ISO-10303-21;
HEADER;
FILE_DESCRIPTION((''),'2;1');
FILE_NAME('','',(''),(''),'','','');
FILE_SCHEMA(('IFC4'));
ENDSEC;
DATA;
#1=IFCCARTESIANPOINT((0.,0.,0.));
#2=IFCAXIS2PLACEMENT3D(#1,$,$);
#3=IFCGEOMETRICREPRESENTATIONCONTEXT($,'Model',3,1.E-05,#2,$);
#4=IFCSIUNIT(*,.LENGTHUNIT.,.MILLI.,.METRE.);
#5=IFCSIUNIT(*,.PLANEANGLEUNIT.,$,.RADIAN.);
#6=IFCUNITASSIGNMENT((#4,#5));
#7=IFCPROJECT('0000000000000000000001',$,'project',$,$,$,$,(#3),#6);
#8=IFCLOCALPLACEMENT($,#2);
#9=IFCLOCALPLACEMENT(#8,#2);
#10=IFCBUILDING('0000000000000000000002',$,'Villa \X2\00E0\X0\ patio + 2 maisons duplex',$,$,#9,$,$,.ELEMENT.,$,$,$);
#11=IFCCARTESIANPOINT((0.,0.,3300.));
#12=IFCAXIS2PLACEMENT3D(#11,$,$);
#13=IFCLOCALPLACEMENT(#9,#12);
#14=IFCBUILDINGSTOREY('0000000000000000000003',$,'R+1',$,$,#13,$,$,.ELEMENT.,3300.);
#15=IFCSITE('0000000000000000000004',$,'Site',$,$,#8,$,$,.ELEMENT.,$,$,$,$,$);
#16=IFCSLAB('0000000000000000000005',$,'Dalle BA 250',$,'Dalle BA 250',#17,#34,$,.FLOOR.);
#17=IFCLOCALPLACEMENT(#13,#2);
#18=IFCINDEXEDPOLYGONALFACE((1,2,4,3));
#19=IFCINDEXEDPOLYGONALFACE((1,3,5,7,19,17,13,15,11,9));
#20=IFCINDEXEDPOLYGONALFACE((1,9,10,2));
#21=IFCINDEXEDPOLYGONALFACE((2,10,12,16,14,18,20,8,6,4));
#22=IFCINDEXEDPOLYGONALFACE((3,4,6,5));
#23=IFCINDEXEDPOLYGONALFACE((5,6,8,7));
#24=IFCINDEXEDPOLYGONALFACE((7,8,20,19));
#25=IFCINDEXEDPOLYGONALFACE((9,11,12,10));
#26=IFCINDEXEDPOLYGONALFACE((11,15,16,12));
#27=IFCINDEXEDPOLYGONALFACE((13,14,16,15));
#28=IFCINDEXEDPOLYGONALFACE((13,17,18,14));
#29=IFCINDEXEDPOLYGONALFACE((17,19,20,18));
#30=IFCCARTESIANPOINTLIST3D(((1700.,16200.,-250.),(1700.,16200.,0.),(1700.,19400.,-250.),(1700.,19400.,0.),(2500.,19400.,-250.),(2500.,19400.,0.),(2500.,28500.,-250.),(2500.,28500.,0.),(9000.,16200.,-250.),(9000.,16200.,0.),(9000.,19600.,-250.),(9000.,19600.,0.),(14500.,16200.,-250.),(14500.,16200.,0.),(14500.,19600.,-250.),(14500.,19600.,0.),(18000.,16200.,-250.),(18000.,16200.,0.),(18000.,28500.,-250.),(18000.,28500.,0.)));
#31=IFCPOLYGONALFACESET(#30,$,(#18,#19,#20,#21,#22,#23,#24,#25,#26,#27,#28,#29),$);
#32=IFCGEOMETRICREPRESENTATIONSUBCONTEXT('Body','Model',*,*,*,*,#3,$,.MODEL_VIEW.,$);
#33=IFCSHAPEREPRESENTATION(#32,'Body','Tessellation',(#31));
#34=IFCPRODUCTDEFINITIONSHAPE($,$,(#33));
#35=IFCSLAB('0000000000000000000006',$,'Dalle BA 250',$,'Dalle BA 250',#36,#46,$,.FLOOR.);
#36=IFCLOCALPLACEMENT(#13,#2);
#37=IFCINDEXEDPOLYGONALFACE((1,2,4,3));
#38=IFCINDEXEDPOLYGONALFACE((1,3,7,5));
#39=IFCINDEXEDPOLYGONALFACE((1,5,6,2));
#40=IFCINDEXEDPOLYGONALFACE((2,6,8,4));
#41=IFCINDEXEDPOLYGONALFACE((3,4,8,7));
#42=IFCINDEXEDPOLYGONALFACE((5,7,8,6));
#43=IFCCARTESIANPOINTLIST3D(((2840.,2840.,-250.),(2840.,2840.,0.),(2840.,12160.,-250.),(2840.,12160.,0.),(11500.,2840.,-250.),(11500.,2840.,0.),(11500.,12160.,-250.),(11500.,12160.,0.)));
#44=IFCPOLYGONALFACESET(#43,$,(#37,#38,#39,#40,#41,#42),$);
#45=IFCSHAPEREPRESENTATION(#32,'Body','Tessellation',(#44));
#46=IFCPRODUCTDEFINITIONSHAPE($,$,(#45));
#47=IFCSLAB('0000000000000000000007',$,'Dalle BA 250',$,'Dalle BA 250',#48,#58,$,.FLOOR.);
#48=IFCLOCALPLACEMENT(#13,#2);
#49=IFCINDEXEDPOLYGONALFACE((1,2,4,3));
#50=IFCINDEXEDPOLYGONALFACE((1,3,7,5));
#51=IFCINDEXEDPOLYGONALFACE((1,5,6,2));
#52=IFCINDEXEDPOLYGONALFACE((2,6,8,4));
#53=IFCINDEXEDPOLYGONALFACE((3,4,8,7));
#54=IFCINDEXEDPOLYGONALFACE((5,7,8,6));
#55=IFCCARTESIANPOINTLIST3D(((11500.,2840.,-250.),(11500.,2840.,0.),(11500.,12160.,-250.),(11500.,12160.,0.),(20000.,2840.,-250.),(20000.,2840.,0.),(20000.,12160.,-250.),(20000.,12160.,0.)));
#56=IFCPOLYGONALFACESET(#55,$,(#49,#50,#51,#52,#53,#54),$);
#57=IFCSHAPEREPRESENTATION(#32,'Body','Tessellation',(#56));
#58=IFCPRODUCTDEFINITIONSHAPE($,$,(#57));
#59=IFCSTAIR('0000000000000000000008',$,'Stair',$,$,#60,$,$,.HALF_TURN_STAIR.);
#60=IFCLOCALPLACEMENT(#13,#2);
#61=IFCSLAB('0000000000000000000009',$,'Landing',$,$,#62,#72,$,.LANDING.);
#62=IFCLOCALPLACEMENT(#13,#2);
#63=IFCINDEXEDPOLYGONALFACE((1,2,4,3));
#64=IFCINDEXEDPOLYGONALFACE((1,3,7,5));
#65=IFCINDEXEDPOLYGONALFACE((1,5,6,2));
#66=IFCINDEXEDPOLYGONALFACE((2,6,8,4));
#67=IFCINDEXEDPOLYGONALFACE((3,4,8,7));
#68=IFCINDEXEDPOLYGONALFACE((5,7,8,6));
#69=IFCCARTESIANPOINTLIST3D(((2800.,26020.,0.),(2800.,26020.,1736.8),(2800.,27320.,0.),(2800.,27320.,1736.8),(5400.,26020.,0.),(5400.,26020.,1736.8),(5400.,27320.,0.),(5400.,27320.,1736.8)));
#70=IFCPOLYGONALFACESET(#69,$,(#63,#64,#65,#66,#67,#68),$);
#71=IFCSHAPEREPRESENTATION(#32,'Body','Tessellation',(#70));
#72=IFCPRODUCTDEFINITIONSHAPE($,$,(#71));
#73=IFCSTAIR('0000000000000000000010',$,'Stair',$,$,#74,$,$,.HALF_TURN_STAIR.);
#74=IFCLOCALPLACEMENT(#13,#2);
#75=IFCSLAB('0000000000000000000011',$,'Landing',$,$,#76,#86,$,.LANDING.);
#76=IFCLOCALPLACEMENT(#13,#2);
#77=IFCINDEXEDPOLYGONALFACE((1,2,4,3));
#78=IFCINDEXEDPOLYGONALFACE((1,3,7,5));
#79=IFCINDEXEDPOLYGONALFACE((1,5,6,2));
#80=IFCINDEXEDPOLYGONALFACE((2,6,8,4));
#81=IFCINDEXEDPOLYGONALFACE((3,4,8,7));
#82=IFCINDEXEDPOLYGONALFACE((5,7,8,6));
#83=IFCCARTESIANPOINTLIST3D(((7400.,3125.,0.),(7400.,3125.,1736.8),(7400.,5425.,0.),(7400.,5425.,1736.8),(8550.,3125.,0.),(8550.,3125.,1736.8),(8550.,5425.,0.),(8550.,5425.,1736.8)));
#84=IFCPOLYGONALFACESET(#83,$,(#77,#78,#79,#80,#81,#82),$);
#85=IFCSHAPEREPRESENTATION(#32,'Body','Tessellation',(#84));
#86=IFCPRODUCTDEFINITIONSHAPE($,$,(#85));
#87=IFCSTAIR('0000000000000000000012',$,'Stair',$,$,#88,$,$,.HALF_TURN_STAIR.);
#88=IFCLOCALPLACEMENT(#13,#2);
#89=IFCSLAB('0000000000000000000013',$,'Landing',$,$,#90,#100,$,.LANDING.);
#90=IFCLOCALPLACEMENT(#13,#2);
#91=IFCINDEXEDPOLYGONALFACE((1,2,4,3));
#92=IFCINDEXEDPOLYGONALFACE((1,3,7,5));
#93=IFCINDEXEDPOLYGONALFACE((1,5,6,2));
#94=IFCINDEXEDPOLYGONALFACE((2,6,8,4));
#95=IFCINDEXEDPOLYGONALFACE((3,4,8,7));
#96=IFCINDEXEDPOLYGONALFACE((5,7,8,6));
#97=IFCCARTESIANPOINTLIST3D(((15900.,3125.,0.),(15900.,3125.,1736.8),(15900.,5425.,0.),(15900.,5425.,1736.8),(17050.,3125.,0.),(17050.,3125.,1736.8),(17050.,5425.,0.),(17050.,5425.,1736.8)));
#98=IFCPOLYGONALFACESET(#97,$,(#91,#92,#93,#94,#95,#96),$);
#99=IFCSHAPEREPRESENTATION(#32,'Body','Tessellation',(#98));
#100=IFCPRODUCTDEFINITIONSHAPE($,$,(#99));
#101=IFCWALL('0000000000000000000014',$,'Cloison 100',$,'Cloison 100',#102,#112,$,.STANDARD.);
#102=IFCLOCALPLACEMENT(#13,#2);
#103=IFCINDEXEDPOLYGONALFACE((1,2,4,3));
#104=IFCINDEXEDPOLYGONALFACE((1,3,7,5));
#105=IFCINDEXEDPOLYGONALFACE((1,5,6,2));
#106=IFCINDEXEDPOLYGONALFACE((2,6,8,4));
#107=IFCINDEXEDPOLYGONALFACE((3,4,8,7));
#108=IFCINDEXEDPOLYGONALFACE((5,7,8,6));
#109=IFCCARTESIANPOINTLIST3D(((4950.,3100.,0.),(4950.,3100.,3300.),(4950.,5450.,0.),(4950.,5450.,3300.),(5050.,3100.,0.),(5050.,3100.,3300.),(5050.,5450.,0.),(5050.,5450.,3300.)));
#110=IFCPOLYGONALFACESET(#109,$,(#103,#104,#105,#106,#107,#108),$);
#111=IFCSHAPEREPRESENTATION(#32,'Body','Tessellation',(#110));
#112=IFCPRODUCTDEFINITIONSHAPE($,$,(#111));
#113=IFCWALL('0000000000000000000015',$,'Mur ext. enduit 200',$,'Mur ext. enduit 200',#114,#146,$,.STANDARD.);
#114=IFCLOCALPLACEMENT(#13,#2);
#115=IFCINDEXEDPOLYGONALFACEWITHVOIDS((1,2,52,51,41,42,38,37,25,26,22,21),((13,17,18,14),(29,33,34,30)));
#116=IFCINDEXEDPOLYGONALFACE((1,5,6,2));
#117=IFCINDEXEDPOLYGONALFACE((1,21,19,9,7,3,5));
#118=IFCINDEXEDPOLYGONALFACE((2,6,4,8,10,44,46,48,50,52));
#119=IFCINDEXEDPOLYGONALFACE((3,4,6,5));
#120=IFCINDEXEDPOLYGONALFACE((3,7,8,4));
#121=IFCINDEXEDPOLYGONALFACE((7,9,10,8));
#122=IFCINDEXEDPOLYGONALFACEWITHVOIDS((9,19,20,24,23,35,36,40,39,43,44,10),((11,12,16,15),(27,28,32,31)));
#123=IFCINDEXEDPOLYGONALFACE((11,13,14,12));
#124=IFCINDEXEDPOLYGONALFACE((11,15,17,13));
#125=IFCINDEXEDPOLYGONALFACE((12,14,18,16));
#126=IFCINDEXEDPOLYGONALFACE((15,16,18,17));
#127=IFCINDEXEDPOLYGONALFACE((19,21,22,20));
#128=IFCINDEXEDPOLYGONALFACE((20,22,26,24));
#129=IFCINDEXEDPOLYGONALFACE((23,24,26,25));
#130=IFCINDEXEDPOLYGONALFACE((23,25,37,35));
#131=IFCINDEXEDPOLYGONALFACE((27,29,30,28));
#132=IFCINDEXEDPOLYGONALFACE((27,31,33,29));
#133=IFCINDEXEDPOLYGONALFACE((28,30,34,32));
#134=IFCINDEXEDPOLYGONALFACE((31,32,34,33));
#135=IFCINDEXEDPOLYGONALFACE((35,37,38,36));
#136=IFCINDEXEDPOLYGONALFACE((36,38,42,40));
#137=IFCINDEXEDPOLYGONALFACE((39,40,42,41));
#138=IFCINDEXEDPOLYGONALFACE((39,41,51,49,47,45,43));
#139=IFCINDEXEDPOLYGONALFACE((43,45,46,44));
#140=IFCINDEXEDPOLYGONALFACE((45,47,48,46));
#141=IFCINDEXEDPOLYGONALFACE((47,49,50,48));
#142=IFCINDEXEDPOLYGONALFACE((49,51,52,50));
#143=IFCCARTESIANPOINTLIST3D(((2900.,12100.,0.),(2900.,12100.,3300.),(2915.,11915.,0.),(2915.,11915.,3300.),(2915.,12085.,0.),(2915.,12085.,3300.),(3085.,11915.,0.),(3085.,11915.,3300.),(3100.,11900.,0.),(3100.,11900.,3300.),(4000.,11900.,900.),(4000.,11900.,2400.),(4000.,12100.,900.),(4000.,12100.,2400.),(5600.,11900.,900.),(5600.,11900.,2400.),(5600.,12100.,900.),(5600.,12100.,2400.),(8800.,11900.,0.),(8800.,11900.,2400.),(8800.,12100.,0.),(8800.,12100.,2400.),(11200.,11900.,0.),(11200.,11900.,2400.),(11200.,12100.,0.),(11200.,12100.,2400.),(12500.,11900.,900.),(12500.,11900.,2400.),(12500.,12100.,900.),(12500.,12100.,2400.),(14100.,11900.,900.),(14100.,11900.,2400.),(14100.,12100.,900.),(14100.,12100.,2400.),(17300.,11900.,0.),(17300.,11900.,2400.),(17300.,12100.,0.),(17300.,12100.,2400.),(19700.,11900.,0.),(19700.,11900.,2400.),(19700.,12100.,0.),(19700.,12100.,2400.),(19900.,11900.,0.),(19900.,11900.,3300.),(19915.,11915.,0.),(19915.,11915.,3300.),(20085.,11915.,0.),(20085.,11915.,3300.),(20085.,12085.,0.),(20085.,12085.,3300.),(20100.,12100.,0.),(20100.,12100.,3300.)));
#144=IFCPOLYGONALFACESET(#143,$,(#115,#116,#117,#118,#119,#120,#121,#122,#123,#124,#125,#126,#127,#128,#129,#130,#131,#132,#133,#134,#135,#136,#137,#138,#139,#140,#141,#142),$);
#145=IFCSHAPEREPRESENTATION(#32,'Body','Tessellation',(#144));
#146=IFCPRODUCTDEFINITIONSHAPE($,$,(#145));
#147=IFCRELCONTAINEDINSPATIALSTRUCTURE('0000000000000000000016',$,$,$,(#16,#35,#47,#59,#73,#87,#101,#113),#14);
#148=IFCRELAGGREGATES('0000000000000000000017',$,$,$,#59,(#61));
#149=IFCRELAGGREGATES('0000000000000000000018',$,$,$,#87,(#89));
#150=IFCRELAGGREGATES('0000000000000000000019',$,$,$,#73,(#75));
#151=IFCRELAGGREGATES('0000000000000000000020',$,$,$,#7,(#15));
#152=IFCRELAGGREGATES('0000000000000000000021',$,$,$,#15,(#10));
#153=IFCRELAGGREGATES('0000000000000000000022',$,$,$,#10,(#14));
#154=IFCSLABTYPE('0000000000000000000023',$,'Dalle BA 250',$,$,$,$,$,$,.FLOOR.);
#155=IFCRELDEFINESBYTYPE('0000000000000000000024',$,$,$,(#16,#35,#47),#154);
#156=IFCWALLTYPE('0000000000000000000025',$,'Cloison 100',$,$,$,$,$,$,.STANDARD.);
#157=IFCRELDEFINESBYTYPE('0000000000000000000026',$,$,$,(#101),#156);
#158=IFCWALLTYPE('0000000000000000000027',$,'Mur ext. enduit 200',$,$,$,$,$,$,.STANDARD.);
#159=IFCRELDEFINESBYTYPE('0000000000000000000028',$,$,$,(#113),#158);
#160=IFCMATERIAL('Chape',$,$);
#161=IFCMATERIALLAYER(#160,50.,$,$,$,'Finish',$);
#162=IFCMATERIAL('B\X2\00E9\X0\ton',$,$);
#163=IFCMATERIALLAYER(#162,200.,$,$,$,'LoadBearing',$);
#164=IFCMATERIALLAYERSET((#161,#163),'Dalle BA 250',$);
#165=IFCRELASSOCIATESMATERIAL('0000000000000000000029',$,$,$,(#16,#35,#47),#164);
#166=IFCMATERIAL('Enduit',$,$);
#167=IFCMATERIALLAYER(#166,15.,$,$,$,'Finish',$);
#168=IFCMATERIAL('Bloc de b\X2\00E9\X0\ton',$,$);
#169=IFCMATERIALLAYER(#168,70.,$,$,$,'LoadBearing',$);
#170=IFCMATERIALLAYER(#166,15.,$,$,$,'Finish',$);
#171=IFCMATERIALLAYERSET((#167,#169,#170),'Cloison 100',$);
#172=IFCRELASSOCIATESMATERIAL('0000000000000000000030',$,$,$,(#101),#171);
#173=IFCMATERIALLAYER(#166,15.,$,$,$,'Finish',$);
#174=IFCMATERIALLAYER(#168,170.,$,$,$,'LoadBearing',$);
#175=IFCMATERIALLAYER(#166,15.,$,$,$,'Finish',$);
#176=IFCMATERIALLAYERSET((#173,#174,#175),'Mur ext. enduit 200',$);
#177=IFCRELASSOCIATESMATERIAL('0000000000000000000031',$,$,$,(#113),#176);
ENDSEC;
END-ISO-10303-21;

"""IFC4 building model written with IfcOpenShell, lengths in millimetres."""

from ifc_helpers import new_model, si_unit, frame, frame_2d, origin, place, context, subcontext, project, spatial, polyline, rectangle, outline, extrude, material, layer, layer_set, layer_usage, type_object, element, aggregate, save


model = new_model("IFC4")

# Units and contexts
model_context = context("Model", 3, precision=1e-05, world=origin())
body_context = subcontext(model_context, "Body", "Model", "MODEL_VIEW")
ifc_project = project(units=[si_unit("LENGTHUNIT", "METRE", prefix="MILLI"), si_unit("PLANEANGLEUNIT", "RADIAN")], contexts=[model_context])

# Site, building, storey
site_placement = place(None, origin())
site = spatial("IfcSite", under=ifc_project, at=site_placement, Name="Site", CompositionType="ELEMENT")
building_placement = place(site_placement, origin())
building = spatial("IfcBuilding", under=site, at=building_placement, Name="Villa à patio + 2 maisons duplex", CompositionType="ELEMENT")
storey_placement = place(building_placement, frame((0.0, 0.0, 3300.0)))
storey = spatial("IfcBuildingStorey", under=building, at=storey_placement, Name="R+1", CompositionType="ELEMENT", Elevation=3300.0)

# Slabs
ifc_material_1 = material(Name="Chape")
ifc_layer_1 = layer(ifc_material_1, 50.0, Category="Finish")
ifc_material_2 = material(Name="Béton")
ifc_layer_2 = layer(ifc_material_2, 200.0, Category="LoadBearing")
ifc_layer_set_1 = layer_set([ifc_layer_1, ifc_layer_2], Name="Dalle BA 250")
ifc_layer_usage_1 = layer_usage(ifc_layer_set_1, "AXIS3", "NEGATIVE", 0.0)
slab_type = type_object("IfcSlabType", Name="Dalle BA 250", PredefinedType="FLOOR")
slab_1_placement = place(storey_placement, origin())
element("IfcSlab", 1, at=slab_1_placement, inside=storey, type_object=slab_type, material=ifc_layer_usage_1, Name="Dalle BA 250", ObjectType="Dalle BA 250", PredefinedType="FLOOR", context=body_context, shape_type="SweptSolid", body=[
    extrude(outline(polyline([(2500.0, 28500.0), (2500.0, 19400.0), (1700.0, 19400.0), (1700.0, 16200.0), (9000.0, 16200.0), (9000.0, 19600.0), (14500.0, 19600.0), (14500.0, 16200.0), (18000.0, 16200.0), (18000.0, 28500.0), (2500.0, 28500.0)])), frame((0.0, 0.0, -250.0)), (0.0, 0.0, 1.0), 250.0),
])
slab_2_placement = place(storey_placement, origin())
element("IfcSlab", 2, at=slab_2_placement, inside=storey, type_object=slab_type, material=ifc_layer_usage_1, Name="Dalle BA 250", ObjectType="Dalle BA 250", PredefinedType="FLOOR", context=body_context, shape_type="SweptSolid", body=[
    extrude(outline(polyline([(2840.0, 12160.0), (2840.0, 2840.0), (11500.0, 2840.0), (11500.0, 12160.0), (2840.0, 12160.0)])), frame((0.0, 0.0, -250.0)), (0.0, 0.0, 1.0), 250.0),
])
slab_3_placement = place(storey_placement, origin())
element("IfcSlab", 3, at=slab_3_placement, inside=storey, type_object=slab_type, material=ifc_layer_usage_1, Name="Dalle BA 250", ObjectType="Dalle BA 250", PredefinedType="FLOOR", context=body_context, shape_type="SweptSolid", body=[
    extrude(outline(polyline([(11500.0, 12160.0), (11500.0, 2840.0), (20000.0, 2840.0), (20000.0, 12160.0), (11500.0, 12160.0)])), frame((0.0, 0.0, -250.0)), (0.0, 0.0, 1.0), 250.0),
])

# Stairs, slabs
stair_1_placement = place(storey_placement, origin())
stair_1 = element("IfcStair", 4, at=stair_1_placement, inside=storey, Name="Stair", PredefinedType="HALF_TURN_STAIR")
slab_4_placement = place(stair_1_placement, origin())
slab_4 = element("IfcSlab", 5, at=slab_4_placement, Name="Landing", PredefinedType="LANDING", context=body_context, shape_type="SweptSolid", body=[
    extrude(outline(polyline([(5400.0, 26020.0), (5400.0, 27320.0), (2800.0, 27320.0), (2800.0, 26020.0), (5400.0, 26020.0)])), origin(), (0.0, 0.0, 1.0), 1736.8),
])
aggregate(stair_1, [slab_4])
stair_2_placement = place(storey_placement, origin())
stair_2 = element("IfcStair", 6, at=stair_2_placement, inside=storey, Name="Stair", PredefinedType="HALF_TURN_STAIR")
slab_5_placement = place(stair_2_placement, origin())
slab_5 = element("IfcSlab", 7, at=slab_5_placement, Name="Landing", PredefinedType="LANDING", context=body_context, shape_type="SweptSolid", body=[
    extrude(outline(polyline([(7400.0, 3125.0), (8550.0, 3125.0), (8550.0, 5425.0), (7400.0, 5425.0), (7400.0, 3125.0)])), origin(), (0.0, 0.0, 1.0), 1736.8),
])
stair_3_placement = place(storey_placement, origin())
stair_3 = element("IfcStair", 8, at=stair_3_placement, inside=storey, Name="Stair", PredefinedType="HALF_TURN_STAIR")
slab_6_placement = place(stair_3_placement, origin())
slab_6 = element("IfcSlab", 9, at=slab_6_placement, Name="Landing", PredefinedType="LANDING", context=body_context, shape_type="SweptSolid", body=[
    extrude(outline(polyline([(15900.0, 3125.0), (17050.0, 3125.0), (17050.0, 5425.0), (15900.0, 5425.0), (15900.0, 3125.0)])), origin(), (0.0, 0.0, 1.0), 1736.8),
])
aggregate(stair_3, [slab_6])

# Shared definitions
ifc_material_3 = material(Name="Enduit")
ifc_layer_3 = layer(ifc_material_3, 15.0, Category="Finish")
ifc_material_4 = material(Name="Bloc de béton")
ifc_layer_4 = layer(ifc_material_4, 70.0, Category="LoadBearing")
ifc_layer_5 = layer(ifc_material_3, 15.0, Category="Finish")
ifc_layer_set_2 = layer_set([ifc_layer_3, ifc_layer_4, ifc_layer_5], Name="Cloison 100")
ifc_layer_usage_2 = layer_usage(ifc_layer_set_2, "AXIS2", "NEGATIVE", 50.0)
wall_type_1 = type_object("IfcWallType", Name="Cloison 100", PredefinedType="STANDARD")

# Wall
wall_1_placement = place(storey_placement, frame((5000.0, 5500.0, 0.0), z_axis=(0.0, 0.0, 1.0), x_axis=(0.0, -1.0, 0.0)))
element("IfcWall", 10, at=wall_1_placement, inside=storey, type_object=wall_type_1, material=ifc_layer_usage_2, Name="Cloison 100", ObjectType="Cloison 100", PredefinedType="STANDARD", context=body_context, shape_type="SweptSolid", body=[
    extrude(outline(polyline([(50.0, -50.0), (50.0, 50.0), (2400.0, 50.0), (2400.0, -50.0), (50.0, -50.0)])), origin(), (0.0, 0.0, 1.0), 3300.0),
])

# Wall, openings
ifc_layer_6 = layer(ifc_material_3, 15.0, Category="Finish")
ifc_layer_7 = layer(ifc_material_4, 170.0, Category="LoadBearing")
ifc_layer_8 = layer(ifc_material_3, 15.0, Category="Finish")
ifc_layer_set_3 = layer_set([ifc_layer_6, ifc_layer_7, ifc_layer_8], Name="Mur ext. enduit 200")
ifc_layer_usage_3 = layer_usage(ifc_layer_set_3, "AXIS2", "NEGATIVE", 100.0)
wall_type_2 = type_object("IfcWallType", Name="Mur ext. enduit 200", PredefinedType="STANDARD")
wall_2_placement = place(storey_placement, frame((3000.0, 12000.0, 0.0), z_axis=(0.0, 0.0, 1.0), x_axis=(1.0, 0.0, 0.0)))
wall_2 = element("IfcWall", 11, at=wall_2_placement, inside=storey, type_object=wall_type_2, material=ifc_layer_usage_3, Name="Mur ext. enduit 200", ObjectType="Mur ext. enduit 200", PredefinedType="STANDARD", context=body_context, shape_type="SweptSolid", body=[
    extrude(outline(polyline([(100.0, -100.0), (85.0, -85.0), (-85.0, -85.0), (-85.0, 85.0), (-100.0, 100.0), (17100.0, 100.0), (17085.0, 85.0), (17085.0, -85.0), (16915.0, -85.0), (16900.0, -100.0), (100.0, -100.0)])), origin(), (0.0, 0.0, 1.0), 3300.0),
])
opening_1_placement = place(wall_2_placement, frame((1000.0, 0.0, 900.0), z_axis=(0.0, 0.0, 1.0), x_axis=(1.0, 0.0, 0.0)))
element("IfcOpeningElement", 12, at=opening_1_placement, cuts=wall_2, PredefinedType="OPENING", context=body_context, shape_type="SweptSolid", body=[
    extrude(rectangle(XDim=1600.0, YDim=220.0, at=frame_2d((800.0, 0.0))), origin(), (0.0, 0.0, 1.0), 1500.0),
])
opening_2_placement = place(wall_2_placement, frame((5800.0, 0.0, 0.0), z_axis=(0.0, 0.0, 1.0), x_axis=(1.0, 0.0, 0.0)))
element("IfcOpeningElement", 13, at=opening_2_placement, cuts=wall_2, PredefinedType="OPENING", context=body_context, shape_type="SweptSolid", body=[
    extrude(rectangle(XDim=2400.0, YDim=220.0, at=frame_2d((1200.0, 0.0))), origin(), (0.0, 0.0, 1.0), 2400.0),
])
opening_3_placement = place(wall_2_placement, frame((9500.0, 0.0, 900.0), z_axis=(0.0, 0.0, 1.0), x_axis=(1.0, 0.0, 0.0)))
element("IfcOpeningElement", 14, at=opening_3_placement, cuts=wall_2, PredefinedType="OPENING", context=body_context, shape_type="SweptSolid", body=[
    extrude(rectangle(XDim=1600.0, YDim=220.0, at=frame_2d((800.0, 0.0))), origin(), (0.0, 0.0, 1.0), 1500.0),
])
opening_4_placement = place(wall_2_placement, frame((14300.0, 0.0, 0.0), z_axis=(0.0, 0.0, 1.0), x_axis=(1.0, 0.0, 0.0)))
element("IfcOpeningElement", 15, at=opening_4_placement, cuts=wall_2, PredefinedType="OPENING", context=body_context, shape_type="SweptSolid", body=[
    extrude(rectangle(XDim=2400.0, YDim=220.0, at=frame_2d((1200.0, 0.0))), origin(), (0.0, 0.0, 1.0), 2400.0),
])

aggregate(stair_2, [slab_5])

save(model, "model.ifc")
